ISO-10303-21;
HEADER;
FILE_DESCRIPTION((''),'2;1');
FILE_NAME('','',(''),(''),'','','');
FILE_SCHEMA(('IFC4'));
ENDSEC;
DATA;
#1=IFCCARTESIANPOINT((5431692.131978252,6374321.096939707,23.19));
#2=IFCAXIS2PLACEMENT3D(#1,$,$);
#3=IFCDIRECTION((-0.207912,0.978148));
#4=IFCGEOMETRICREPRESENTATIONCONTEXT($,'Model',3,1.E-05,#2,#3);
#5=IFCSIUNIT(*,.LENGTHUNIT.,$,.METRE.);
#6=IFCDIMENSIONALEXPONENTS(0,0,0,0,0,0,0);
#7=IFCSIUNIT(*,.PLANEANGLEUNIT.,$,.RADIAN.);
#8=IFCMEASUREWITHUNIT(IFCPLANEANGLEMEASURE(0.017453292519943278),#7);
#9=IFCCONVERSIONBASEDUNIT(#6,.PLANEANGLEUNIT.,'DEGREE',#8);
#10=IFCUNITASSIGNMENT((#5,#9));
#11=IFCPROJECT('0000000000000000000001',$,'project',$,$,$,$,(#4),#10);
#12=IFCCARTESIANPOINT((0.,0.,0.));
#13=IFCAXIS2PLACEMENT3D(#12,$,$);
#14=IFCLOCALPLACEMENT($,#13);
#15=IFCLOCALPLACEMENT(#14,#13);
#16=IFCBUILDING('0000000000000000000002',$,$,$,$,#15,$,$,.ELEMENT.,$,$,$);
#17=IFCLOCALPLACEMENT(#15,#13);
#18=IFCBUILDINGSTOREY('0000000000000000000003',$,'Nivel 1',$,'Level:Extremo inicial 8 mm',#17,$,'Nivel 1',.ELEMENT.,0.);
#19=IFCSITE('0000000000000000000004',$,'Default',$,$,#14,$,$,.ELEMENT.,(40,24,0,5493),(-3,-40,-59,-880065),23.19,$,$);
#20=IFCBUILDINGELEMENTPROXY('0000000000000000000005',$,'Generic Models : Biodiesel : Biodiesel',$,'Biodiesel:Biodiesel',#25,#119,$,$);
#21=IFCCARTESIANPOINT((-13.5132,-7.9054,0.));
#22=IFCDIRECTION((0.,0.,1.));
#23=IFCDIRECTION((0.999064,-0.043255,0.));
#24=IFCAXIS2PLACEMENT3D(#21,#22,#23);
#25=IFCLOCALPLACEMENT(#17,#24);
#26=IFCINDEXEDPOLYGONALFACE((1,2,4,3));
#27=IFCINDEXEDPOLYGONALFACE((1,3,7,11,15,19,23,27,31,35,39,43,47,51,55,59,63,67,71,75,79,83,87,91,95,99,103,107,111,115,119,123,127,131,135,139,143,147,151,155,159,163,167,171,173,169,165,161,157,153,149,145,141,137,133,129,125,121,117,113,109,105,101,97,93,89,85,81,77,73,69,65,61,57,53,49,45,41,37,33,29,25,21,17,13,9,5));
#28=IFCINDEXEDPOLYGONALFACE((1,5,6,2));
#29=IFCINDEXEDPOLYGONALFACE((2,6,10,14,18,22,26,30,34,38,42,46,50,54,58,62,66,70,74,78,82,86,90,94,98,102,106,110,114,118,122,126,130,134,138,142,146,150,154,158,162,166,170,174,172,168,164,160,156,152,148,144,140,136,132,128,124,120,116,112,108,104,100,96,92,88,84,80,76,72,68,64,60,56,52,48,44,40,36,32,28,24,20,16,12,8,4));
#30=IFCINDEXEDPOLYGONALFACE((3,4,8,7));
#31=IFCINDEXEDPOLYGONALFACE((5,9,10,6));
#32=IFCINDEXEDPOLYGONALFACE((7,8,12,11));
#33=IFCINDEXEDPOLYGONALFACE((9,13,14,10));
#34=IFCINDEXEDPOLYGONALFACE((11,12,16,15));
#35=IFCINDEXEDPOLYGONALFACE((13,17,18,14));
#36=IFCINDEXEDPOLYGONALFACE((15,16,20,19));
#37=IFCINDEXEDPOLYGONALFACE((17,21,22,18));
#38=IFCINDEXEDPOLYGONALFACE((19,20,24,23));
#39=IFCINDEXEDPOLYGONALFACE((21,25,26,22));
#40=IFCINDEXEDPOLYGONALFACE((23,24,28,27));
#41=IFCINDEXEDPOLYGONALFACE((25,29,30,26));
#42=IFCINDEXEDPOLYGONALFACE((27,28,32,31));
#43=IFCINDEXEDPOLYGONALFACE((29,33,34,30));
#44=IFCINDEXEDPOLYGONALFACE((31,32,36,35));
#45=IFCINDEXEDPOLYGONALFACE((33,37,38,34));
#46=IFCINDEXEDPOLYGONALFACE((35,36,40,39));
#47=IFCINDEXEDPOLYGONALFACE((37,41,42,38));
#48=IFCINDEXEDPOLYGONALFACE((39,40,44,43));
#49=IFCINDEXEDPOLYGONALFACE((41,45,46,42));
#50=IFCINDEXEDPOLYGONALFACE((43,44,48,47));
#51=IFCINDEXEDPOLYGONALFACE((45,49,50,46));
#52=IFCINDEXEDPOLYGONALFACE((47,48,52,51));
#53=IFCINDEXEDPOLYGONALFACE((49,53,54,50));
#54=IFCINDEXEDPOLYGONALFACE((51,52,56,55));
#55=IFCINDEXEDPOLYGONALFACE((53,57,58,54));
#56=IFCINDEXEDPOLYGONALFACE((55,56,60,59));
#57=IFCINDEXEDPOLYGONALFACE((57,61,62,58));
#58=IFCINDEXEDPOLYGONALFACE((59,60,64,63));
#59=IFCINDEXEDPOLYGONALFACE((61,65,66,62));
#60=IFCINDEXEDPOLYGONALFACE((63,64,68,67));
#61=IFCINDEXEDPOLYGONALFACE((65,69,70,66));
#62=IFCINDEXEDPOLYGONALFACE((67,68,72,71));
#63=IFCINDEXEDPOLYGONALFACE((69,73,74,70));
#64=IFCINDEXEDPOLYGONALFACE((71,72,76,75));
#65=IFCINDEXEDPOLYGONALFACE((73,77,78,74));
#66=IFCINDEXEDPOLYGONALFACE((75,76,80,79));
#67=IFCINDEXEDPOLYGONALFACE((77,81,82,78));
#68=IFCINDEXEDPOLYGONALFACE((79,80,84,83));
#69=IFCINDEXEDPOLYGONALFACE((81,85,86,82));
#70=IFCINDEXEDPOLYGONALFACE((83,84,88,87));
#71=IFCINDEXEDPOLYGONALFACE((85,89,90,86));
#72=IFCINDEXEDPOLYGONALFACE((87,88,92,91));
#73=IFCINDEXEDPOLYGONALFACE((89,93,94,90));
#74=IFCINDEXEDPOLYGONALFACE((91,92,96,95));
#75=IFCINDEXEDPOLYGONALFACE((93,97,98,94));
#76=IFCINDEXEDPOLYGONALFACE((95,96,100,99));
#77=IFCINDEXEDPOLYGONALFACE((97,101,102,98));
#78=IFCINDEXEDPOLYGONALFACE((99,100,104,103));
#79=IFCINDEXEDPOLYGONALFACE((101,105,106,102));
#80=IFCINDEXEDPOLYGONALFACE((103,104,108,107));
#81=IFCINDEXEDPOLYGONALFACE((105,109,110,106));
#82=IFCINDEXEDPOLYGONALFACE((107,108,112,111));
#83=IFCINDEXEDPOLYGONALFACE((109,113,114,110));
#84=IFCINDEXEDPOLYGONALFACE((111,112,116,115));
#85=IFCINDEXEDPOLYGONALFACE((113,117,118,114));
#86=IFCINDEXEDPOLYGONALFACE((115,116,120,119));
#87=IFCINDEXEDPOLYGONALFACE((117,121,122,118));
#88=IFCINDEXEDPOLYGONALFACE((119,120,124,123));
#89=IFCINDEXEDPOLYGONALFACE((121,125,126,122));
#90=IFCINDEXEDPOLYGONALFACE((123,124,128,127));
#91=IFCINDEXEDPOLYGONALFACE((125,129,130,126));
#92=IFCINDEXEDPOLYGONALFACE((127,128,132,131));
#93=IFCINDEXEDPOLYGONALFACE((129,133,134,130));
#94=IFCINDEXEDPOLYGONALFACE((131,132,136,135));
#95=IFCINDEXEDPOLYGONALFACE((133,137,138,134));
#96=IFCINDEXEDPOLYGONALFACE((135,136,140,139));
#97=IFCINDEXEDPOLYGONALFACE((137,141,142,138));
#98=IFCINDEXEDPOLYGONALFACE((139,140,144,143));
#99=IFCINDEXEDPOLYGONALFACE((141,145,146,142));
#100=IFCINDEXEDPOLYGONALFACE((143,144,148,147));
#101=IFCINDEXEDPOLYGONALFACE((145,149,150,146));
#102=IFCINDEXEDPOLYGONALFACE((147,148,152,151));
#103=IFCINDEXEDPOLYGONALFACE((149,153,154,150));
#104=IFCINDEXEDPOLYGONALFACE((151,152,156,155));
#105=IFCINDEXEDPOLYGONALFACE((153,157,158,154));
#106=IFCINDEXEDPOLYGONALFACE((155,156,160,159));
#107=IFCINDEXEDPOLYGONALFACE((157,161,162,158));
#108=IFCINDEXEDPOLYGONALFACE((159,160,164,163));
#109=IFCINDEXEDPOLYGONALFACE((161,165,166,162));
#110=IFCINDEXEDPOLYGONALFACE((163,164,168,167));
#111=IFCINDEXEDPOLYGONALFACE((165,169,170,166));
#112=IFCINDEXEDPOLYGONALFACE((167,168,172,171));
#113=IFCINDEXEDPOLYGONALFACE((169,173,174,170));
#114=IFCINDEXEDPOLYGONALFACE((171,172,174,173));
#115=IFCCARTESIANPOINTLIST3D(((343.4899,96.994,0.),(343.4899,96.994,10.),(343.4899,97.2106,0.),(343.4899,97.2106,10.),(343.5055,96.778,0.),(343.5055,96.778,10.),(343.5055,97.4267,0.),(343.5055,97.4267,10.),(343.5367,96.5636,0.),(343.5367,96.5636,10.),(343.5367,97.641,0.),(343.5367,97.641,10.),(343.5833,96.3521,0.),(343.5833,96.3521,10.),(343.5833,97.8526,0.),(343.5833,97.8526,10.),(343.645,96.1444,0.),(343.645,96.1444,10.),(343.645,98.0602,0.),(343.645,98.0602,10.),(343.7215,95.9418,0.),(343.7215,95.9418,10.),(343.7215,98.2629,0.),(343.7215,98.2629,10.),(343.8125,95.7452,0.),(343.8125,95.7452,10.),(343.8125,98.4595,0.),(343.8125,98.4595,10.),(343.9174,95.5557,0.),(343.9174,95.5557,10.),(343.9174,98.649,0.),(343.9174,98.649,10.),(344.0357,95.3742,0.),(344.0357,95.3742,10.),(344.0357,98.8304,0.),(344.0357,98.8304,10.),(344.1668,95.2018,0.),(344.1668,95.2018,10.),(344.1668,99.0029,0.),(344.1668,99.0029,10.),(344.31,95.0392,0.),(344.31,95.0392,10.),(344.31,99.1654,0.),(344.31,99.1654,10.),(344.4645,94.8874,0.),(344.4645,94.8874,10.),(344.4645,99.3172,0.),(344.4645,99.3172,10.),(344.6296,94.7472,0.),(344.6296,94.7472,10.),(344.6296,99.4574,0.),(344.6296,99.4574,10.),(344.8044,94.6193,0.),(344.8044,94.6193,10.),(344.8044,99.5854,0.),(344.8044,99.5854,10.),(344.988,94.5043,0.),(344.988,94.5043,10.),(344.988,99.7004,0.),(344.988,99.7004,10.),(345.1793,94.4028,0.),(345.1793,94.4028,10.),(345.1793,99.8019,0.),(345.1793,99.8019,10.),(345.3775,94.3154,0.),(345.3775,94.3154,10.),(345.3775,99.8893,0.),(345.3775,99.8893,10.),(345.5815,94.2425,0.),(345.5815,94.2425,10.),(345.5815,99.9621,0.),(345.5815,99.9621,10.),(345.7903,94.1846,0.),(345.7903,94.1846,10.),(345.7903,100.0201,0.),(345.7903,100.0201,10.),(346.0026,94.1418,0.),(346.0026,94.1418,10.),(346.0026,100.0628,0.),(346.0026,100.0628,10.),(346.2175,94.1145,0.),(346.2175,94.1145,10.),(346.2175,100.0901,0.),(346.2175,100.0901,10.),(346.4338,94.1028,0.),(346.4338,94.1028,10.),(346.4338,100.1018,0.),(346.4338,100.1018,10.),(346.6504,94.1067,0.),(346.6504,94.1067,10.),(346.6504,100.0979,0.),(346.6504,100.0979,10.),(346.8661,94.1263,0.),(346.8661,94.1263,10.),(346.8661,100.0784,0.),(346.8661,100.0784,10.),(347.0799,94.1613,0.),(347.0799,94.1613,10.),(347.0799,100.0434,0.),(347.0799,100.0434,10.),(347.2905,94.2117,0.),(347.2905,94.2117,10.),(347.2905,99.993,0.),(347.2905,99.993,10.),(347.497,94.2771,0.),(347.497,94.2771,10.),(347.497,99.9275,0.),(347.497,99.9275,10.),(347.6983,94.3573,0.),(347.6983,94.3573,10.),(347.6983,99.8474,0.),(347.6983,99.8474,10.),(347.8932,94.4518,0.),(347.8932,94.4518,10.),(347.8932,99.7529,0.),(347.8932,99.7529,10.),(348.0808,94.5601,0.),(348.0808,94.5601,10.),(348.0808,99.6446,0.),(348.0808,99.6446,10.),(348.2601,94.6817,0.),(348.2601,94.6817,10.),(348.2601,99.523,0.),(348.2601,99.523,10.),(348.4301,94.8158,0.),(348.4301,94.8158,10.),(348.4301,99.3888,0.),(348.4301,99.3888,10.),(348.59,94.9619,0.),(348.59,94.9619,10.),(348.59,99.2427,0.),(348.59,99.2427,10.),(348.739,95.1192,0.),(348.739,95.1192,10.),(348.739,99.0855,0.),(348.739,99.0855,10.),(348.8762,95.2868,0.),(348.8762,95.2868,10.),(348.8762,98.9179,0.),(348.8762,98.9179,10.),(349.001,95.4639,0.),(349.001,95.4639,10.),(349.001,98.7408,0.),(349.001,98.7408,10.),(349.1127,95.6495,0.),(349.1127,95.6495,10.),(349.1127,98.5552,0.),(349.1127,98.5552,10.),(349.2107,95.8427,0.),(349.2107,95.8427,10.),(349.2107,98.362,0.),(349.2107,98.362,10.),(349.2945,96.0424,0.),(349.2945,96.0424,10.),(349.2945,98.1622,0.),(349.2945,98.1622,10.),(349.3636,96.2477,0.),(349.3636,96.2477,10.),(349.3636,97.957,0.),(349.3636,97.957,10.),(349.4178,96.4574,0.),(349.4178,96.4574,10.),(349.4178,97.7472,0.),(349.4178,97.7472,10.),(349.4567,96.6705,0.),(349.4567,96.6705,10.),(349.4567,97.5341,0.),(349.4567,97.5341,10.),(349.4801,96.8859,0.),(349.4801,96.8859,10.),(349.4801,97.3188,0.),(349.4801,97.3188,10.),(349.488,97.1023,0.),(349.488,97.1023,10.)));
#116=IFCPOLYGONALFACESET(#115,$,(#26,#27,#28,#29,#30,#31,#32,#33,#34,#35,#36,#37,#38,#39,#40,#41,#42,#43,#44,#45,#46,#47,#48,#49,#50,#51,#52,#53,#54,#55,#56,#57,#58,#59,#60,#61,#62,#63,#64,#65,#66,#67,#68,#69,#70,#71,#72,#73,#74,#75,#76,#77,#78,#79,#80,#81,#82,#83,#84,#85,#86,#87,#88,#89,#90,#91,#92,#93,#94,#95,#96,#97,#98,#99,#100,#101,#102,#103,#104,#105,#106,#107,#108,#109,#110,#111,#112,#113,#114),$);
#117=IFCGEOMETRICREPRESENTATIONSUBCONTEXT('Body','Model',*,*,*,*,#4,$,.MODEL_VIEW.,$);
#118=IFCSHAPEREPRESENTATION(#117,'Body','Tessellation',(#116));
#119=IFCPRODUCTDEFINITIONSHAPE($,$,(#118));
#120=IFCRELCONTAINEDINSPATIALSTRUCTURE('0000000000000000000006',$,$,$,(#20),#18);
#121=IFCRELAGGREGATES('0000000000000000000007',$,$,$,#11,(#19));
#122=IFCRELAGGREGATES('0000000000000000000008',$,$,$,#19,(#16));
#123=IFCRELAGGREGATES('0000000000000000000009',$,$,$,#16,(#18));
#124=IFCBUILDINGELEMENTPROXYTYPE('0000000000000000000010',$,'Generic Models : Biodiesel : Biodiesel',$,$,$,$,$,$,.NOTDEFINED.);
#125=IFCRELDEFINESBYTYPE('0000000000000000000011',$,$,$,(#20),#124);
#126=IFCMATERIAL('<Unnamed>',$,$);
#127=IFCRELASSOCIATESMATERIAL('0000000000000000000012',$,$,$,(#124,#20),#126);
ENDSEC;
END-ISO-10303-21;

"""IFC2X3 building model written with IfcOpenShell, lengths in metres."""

from ifc_helpers import new_model, entity, si_unit, converted_unit, direction, frame, frame_2d, origin, place, context, subcontext, project, spatial, circle, extrude, source, transform, mapped, material, type_object, type_shapes, element, save


model = new_model("IFC2X3")

# Units and contexts
model_context = context("Model", 3, precision=1e-05, world=frame((5431692.131978252, 6374321.096939707, 23.19)), true_north=direction((-0.207912, 0.978148)))
body_context = subcontext(model_context, "Body", "Model", "MODEL_VIEW")
ifc_project = project(units=[si_unit("LENGTHUNIT", "METRE"), converted_unit("PLANEANGLEUNIT", "DEGREE", entity("IfcPlaneAngleMeasure", 0.017453292519943278), si_unit("PLANEANGLEUNIT", "RADIAN"), dimensions=[0, 0, 0, 0, 0, 0, 0])], contexts=[model_context])

# Site, building, storey
site_placement = place(None, origin())
site = spatial("IfcSite", under=ifc_project, at=site_placement, Name="Default", CompositionType="ELEMENT", RefLatitude=(40, 24, 0, 5493), RefLongitude=(-3, -40, -59, -880065), RefElevation=23.19)
building_placement = place(site_placement, origin())
building = spatial("IfcBuilding", under=site, at=building_placement, CompositionType="ELEMENT")
storey_placement = place(building_placement, origin())
storey = spatial("IfcBuildingStorey", under=building, at=storey_placement, Name="Nivel 1", ObjectType="Level:Extremo inicial 8 mm", LongName="Nivel 1", CompositionType="ELEMENT", Elevation=0.0)

# Building element proxy
ifc_material_1 = material(Name="<Unnamed>")
building_element_proxy_type_1 = type_object("IfcBuildingElementProxyType", Name="Generic Models : Biodiesel : Biodiesel", PredefinedType="NOTDEFINED", material=ifc_material_1)
shared_shape_1 = source(origin(), body_context, "Body", "SweptSolid", [
    extrude(circle(Radius=3.0, at=frame_2d((0.0, 0.0), x_axis=(1.0, 0.0))), frame((346.488, 97.1023, 0.0)), (0.0, 0.0, 1.0), 10.0),
])
type_shapes(building_element_proxy_type_1, [shared_shape_1])
proxy_1_placement = place(storey_placement, frame((-13.5132, -7.9054, 0.0), z_axis=(0.0, 0.0, 1.0), x_axis=(0.999064, -0.043255, 0.0)))
element("IfcBuildingElementProxy", 1, at=proxy_1_placement, inside=storey, type_object=building_element_proxy_type_1, material=ifc_material_1, Name="Generic Models : Biodiesel : Biodiesel", ObjectType="Biodiesel:Biodiesel", context=body_context, shape_type="MappedRepresentation", body=[
    mapped(shared_shape_1, transform((0.0, 0.0, 0.0), scale=1.0)),
])

save(model, "model.ifc")
